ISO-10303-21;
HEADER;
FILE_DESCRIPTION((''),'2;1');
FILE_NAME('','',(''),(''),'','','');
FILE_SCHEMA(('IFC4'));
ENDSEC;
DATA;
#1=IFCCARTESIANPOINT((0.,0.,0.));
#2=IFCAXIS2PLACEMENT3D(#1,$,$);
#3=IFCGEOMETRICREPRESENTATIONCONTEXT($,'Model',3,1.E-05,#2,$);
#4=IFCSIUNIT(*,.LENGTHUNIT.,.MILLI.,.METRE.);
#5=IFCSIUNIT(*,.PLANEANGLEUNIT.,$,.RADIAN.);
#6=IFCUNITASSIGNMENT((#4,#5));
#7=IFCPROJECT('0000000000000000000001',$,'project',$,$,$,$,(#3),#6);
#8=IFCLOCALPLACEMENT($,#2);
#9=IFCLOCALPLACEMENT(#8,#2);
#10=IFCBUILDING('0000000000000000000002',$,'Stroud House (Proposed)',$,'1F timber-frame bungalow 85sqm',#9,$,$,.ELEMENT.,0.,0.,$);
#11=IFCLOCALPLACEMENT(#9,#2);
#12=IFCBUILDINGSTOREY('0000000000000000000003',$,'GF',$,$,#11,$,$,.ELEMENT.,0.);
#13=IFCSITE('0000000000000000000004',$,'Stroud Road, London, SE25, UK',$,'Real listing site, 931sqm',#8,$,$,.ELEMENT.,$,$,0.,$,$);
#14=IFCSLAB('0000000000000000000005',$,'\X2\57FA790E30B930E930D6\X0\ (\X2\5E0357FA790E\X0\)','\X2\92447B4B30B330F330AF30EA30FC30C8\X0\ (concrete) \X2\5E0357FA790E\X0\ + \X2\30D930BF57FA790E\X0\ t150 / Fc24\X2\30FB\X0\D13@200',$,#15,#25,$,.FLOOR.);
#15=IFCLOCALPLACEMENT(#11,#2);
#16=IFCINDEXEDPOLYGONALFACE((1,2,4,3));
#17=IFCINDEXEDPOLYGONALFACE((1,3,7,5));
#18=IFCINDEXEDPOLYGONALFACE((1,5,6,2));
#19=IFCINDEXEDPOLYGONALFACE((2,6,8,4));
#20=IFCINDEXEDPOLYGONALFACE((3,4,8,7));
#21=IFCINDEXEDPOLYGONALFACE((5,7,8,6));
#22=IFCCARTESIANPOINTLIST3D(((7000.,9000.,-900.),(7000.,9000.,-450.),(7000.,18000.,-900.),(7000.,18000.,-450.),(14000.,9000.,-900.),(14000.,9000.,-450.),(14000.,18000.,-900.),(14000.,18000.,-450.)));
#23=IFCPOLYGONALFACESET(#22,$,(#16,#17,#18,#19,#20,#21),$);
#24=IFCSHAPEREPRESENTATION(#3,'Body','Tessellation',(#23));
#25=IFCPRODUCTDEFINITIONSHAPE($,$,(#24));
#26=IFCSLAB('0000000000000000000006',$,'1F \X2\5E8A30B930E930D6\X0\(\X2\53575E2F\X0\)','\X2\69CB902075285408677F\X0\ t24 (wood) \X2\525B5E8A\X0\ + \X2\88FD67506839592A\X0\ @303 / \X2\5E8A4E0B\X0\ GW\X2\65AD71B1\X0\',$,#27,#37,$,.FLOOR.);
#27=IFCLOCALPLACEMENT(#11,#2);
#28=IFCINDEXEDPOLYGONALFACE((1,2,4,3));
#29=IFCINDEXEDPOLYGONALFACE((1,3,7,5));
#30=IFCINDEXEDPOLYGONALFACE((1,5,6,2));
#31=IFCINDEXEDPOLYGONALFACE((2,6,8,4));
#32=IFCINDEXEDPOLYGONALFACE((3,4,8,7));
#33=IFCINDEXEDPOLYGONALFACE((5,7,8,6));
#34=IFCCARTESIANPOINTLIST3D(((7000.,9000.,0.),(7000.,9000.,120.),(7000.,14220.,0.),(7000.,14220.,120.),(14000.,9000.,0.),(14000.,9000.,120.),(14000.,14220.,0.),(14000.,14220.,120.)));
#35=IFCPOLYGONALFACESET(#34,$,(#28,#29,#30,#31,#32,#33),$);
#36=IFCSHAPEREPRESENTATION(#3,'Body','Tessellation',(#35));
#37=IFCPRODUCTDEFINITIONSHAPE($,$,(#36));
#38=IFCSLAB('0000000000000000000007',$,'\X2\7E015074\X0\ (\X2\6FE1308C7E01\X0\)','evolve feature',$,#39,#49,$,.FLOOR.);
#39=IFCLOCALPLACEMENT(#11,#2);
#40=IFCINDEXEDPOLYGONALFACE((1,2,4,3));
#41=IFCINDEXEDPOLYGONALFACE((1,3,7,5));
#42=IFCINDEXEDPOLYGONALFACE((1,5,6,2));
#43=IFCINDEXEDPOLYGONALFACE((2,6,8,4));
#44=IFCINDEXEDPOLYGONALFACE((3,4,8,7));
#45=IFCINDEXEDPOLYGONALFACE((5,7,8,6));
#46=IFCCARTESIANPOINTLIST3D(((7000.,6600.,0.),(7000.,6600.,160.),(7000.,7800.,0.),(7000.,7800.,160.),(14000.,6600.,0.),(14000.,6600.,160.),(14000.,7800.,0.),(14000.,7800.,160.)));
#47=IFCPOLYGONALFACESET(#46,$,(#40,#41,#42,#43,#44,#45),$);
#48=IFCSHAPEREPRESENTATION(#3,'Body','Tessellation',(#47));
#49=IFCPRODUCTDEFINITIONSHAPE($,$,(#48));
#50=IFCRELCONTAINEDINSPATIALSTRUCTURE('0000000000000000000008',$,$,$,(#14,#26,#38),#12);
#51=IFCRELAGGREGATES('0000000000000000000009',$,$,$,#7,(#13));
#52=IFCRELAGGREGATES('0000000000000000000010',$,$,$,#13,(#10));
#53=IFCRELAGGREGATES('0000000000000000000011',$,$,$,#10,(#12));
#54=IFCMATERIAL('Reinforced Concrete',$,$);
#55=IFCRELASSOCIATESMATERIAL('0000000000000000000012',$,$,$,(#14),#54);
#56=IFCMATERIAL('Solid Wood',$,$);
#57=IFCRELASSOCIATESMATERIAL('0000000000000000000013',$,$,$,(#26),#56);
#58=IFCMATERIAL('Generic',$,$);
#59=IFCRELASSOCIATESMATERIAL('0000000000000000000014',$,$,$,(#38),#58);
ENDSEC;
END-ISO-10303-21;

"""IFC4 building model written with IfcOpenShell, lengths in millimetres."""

from ifc_helpers import new_model, si_unit, frame, frame_2d, origin, place, context, project, spatial, rectangle, extrude, material, element, save


model = new_model("IFC4")

# Units and contexts
model_context = context("Model", 3, precision=1e-05, world=origin())
ifc_project = project(units=[si_unit("LENGTHUNIT", "METRE", prefix="MILLI"), si_unit("PLANEANGLEUNIT", "RADIAN")], contexts=[model_context])

# Site, building, storey
site_placement = place(None, origin())
site = spatial("IfcSite", under=ifc_project, at=site_placement, Name="Stroud Road, London, SE25, UK", ObjectType="Real listing site, 931sqm", CompositionType="ELEMENT", RefElevation=0.0)
building_placement = place(site_placement, origin())
building = spatial("IfcBuilding", under=site, at=building_placement, Name="Stroud House (Proposed)", ObjectType="1F timber-frame bungalow 85sqm", CompositionType="ELEMENT", ElevationOfRefHeight=0.0, ElevationOfTerrain=0.0)
storey_placement = place(building_placement, origin())
storey = spatial("IfcBuildingStorey", under=building, at=storey_placement, Name="GF", CompositionType="ELEMENT", Elevation=0.0)

# Slabs
ifc_material_1 = material(Name="Reinforced Concrete")
slab_1_placement = place(storey_placement, frame((3500.0, 4500.0, -450.0)))
element("IfcSlab", 1, at=slab_1_placement, inside=storey, material=ifc_material_1, Name="基礎スラブ (布基礎)", Description="鉄筋コンクリート (concrete) 布基礎 + ベタ基礎 t150 / Fc24・D13@200", PredefinedType="FLOOR", context=model_context, shape_type="SweptSolid", body=[
    extrude(rectangle(XDim=7000.0, YDim=9000.0, at=frame_2d((3500.0, 4500.0))), frame((3500.0, 4500.0, -450.0)), (0.0, 0.0, 1.0), 450.0),
])
ifc_material_2 = material(Name="Solid Wood")
slab_2_placement = place(storey_placement, frame((3500.0, 4500.0, 0.0)))
element("IfcSlab", 2, at=slab_2_placement, inside=storey, material=ifc_material_2, Name="1F 床スラブ(南帯)", Description="構造用合板 t24 (wood) 剛床 + 製材根太 @303 / 床下 GW断熱", PredefinedType="FLOOR", context=model_context, shape_type="SweptSolid", body=[
    extrude(rectangle(XDim=7000.0, YDim=5220.0, at=frame_2d((3500.0, 2610.0))), frame((3500.0, 4500.0, 0.0)), (0.0, 0.0, 1.0), 120.0),
])
ifc_material_3 = material(Name="Generic")
slab_3_placement = place(storey_placement, frame((3500.0, 3300.0, 0.0)))
element("IfcSlab", 3, at=slab_3_placement, inside=storey, material=ifc_material_3, Name="縁側 (濡れ縁)", Description="evolve feature", PredefinedType="FLOOR", context=model_context, shape_type="SweptSolid", body=[
    extrude(rectangle(XDim=7000.0, YDim=1200.0, at=frame_2d((3500.0, 600.0))), frame((3500.0, 3300.0, 0.0)), (0.0, 0.0, 1.0), 160.0),
])

save(model, "model.ifc")
